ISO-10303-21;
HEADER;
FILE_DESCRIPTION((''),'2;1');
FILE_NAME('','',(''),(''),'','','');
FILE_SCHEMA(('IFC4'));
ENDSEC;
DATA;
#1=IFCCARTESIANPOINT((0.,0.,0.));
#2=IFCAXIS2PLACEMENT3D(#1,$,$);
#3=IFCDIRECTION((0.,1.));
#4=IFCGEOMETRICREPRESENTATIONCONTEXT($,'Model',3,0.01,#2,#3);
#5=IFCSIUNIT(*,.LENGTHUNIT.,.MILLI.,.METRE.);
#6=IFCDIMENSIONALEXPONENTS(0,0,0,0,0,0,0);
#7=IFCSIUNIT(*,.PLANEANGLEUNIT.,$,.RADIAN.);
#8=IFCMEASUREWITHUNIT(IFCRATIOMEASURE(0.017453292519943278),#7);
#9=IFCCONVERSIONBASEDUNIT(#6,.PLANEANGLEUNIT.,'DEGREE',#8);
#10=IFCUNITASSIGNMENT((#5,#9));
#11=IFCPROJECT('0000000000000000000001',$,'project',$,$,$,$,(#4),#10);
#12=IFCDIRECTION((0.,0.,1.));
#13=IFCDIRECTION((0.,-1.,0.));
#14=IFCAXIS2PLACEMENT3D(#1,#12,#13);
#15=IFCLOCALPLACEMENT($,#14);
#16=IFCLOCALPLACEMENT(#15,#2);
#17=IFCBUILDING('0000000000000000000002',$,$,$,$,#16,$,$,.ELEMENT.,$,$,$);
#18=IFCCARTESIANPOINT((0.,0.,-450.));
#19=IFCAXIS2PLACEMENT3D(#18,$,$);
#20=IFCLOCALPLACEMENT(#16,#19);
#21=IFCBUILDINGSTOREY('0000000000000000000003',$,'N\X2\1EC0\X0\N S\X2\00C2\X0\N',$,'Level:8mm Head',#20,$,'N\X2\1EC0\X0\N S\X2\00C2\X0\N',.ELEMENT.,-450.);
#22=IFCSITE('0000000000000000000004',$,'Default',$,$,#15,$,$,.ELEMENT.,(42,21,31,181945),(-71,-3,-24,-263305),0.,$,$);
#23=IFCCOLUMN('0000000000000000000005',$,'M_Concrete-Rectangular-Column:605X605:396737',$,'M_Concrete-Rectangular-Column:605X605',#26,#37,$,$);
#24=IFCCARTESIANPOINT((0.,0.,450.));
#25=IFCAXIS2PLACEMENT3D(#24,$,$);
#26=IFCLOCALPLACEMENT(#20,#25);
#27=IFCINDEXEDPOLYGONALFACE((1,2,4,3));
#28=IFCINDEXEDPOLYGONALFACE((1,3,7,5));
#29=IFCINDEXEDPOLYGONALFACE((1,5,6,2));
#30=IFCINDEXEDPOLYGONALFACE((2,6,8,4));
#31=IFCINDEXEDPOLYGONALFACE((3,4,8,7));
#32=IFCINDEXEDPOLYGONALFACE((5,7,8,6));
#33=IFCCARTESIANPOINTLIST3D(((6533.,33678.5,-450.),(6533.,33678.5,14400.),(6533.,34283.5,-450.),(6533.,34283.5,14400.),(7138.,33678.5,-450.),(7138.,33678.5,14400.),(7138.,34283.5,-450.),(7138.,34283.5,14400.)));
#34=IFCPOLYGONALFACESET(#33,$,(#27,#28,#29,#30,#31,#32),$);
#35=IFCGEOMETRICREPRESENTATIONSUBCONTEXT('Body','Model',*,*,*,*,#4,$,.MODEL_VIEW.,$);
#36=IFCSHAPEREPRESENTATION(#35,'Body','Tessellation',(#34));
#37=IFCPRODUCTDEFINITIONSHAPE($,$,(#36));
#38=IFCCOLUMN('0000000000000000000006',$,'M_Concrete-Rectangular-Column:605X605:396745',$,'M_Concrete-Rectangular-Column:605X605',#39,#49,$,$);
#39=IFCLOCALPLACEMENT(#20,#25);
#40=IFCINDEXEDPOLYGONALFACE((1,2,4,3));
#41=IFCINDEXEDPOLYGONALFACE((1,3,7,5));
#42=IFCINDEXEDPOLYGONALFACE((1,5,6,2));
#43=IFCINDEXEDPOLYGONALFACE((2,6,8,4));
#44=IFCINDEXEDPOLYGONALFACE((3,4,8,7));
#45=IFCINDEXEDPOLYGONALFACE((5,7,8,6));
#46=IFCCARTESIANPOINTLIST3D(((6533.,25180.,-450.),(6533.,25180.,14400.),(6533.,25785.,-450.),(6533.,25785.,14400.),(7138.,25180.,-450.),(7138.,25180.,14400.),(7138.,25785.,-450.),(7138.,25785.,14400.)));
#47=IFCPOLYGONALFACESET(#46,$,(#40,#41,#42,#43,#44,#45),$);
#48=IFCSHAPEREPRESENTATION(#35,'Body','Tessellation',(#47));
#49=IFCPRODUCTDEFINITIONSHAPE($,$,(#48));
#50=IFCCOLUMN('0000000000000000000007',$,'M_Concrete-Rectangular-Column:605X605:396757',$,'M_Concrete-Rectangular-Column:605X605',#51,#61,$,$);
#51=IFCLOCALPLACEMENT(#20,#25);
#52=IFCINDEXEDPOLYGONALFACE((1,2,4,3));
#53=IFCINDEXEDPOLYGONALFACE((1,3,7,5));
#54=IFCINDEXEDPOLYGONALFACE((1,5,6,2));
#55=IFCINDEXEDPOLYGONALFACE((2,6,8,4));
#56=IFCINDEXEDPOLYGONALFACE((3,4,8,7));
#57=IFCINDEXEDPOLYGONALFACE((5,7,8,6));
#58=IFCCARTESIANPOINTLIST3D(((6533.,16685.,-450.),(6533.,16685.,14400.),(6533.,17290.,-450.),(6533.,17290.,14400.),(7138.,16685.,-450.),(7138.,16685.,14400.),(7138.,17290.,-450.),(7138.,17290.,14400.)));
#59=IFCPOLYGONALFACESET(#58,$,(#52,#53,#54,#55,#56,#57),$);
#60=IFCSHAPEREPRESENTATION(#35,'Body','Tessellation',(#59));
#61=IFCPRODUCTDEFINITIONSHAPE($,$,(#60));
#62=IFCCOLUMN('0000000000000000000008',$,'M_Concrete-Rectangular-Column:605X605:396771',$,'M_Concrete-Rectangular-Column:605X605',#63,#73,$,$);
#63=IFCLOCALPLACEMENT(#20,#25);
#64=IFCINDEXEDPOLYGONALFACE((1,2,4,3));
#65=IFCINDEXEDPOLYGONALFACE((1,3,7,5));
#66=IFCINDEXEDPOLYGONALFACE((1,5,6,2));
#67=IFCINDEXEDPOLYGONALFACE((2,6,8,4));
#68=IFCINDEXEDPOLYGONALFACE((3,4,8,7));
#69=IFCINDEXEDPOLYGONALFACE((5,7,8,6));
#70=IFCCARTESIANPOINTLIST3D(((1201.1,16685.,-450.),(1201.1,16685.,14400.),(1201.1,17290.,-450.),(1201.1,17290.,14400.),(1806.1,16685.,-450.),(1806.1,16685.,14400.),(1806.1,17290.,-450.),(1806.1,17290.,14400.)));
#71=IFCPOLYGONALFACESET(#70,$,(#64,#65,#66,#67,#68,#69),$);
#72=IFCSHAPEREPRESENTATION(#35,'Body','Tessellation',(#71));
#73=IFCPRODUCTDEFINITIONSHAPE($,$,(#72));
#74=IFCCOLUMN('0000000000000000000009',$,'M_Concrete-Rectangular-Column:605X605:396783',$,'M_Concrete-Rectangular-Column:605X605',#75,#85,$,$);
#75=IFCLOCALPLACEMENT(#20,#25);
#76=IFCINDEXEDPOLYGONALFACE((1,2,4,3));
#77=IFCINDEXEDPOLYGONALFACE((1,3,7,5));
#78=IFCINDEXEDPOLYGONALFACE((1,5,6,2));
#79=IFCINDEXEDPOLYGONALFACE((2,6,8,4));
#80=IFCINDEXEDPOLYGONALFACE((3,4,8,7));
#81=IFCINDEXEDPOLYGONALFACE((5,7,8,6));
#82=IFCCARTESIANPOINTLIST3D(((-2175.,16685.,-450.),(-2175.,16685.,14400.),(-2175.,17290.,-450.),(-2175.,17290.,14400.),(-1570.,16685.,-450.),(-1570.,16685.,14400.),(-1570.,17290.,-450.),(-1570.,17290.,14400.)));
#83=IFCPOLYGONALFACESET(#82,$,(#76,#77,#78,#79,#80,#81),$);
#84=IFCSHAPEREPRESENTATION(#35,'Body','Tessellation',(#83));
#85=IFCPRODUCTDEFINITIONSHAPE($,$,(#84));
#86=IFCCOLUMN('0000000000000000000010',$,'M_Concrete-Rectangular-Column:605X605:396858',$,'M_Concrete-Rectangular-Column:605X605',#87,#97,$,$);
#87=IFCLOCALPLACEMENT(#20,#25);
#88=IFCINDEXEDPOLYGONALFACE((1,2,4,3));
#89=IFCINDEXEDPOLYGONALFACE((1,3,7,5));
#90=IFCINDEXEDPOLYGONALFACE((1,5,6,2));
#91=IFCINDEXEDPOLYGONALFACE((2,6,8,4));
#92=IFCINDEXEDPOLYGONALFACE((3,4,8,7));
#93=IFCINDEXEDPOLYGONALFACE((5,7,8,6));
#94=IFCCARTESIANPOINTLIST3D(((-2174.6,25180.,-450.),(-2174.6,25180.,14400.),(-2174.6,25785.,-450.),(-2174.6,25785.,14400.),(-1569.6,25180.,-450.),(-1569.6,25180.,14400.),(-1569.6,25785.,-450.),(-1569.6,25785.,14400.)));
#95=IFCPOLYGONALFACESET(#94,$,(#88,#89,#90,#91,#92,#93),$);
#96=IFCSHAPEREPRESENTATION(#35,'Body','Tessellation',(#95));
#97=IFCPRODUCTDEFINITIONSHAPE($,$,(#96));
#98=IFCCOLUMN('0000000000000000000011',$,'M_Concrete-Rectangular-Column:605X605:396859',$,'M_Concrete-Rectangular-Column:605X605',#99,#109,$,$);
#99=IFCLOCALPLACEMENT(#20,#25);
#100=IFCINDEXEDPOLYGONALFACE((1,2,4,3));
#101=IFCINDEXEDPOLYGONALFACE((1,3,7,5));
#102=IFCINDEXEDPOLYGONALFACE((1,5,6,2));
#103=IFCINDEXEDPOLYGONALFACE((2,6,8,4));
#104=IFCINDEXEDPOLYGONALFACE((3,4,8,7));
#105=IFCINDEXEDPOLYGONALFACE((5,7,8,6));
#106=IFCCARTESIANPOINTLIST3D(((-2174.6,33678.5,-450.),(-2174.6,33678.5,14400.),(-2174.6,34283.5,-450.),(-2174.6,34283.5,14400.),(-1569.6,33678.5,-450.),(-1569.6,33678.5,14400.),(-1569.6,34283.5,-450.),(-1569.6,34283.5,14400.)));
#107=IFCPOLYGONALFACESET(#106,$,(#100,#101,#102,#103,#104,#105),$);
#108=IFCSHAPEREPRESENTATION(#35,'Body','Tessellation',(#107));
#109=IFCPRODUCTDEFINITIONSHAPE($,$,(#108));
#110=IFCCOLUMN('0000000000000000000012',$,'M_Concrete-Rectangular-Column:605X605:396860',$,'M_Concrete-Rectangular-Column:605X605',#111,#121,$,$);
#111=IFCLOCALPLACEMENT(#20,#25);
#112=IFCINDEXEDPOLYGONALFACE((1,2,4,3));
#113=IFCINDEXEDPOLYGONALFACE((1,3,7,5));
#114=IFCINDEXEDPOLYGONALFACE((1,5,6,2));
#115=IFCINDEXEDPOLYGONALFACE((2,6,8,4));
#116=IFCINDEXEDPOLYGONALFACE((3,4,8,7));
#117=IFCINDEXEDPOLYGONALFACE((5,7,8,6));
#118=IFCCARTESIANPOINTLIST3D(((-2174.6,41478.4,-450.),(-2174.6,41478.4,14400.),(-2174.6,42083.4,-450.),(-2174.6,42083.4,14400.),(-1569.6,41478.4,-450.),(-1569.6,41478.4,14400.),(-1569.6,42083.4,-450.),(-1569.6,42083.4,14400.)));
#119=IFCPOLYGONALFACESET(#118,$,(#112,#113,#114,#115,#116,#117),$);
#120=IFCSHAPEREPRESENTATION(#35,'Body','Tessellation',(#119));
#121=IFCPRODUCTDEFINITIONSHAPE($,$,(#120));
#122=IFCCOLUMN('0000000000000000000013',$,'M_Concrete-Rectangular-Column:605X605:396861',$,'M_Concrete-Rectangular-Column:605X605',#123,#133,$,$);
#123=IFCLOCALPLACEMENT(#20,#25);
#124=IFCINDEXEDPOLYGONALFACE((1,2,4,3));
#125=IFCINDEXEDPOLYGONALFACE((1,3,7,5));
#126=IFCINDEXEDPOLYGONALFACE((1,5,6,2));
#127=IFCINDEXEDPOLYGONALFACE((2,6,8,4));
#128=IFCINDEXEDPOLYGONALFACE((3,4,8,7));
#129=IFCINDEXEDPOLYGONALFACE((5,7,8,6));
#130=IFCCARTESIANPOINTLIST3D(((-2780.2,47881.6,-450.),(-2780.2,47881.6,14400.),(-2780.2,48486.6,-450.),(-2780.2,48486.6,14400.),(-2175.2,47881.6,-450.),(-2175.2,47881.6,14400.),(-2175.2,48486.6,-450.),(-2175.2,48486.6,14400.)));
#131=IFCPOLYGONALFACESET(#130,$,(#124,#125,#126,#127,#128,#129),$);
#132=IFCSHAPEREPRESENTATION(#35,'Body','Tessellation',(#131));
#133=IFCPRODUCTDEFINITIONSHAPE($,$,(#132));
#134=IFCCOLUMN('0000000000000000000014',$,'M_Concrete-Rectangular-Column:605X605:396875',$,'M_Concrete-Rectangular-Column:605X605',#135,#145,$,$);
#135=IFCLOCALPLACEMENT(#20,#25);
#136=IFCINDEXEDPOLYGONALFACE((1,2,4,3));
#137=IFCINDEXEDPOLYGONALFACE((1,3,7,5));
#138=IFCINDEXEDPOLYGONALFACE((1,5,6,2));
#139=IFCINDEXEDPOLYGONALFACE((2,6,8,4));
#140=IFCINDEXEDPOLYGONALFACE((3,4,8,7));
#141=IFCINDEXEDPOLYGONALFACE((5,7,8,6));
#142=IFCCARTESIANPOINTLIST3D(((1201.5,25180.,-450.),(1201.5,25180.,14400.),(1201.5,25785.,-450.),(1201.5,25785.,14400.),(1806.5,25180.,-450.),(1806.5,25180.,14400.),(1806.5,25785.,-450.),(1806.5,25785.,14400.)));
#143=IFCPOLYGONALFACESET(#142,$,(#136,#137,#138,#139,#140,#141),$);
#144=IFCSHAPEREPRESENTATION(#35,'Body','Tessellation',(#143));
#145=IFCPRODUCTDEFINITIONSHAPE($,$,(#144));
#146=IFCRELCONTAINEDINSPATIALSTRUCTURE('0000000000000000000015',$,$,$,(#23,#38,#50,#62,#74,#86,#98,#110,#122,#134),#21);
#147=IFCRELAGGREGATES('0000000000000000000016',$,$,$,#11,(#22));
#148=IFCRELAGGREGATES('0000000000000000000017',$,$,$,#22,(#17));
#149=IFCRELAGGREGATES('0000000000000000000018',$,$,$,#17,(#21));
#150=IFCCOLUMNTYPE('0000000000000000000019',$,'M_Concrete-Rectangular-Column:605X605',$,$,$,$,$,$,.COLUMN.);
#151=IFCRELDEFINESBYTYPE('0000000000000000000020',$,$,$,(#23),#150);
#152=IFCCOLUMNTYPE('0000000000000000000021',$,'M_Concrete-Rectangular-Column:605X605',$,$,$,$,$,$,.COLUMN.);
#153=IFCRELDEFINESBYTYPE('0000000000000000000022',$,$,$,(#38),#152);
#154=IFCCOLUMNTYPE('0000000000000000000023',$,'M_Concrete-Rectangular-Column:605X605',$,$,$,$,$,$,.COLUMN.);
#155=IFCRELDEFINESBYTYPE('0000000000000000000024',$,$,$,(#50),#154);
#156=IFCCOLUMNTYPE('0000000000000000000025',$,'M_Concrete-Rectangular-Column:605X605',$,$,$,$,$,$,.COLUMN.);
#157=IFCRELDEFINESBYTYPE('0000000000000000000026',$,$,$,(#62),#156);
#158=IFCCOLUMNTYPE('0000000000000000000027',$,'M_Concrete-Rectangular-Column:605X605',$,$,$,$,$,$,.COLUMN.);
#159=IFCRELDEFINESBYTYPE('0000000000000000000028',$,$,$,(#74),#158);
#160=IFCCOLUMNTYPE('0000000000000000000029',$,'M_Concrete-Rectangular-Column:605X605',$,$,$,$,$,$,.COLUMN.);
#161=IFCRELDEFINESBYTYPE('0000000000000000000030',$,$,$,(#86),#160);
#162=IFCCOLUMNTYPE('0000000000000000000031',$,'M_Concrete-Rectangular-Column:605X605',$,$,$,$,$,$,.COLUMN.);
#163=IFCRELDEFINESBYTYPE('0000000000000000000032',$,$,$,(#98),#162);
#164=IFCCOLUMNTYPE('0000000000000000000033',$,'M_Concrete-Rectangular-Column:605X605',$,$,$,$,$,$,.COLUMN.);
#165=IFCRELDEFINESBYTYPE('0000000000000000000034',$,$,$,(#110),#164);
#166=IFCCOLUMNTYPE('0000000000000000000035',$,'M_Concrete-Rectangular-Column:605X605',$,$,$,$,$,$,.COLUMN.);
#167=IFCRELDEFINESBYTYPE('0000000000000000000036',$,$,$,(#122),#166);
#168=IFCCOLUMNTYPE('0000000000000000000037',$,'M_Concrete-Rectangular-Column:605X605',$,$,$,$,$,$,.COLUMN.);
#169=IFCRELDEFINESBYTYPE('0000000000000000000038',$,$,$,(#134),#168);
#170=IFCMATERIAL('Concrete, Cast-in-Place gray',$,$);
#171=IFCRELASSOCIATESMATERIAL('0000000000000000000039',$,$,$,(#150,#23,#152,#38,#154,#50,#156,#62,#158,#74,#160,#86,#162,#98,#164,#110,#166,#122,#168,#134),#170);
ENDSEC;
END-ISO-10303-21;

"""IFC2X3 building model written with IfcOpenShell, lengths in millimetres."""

from ifc_helpers import new_model, entity, si_unit, converted_unit, direction, frame, frame_2d, origin, origin_2d_with_axis, place, context, subcontext, project, spatial, rectangle, extrude, source, transform, mapped, material, type_object, type_shapes, element, save


model = new_model("IFC2X3")

# Units and contexts
model_context = context("Model", 3, precision=0.01, world=origin(), true_north=direction((0.0, 1.0)))
body_context = subcontext(model_context, "Body", "Model", "MODEL_VIEW")
ifc_project = project(units=[si_unit("LENGTHUNIT", "METRE", prefix="MILLI"), converted_unit("PLANEANGLEUNIT", "DEGREE", entity("IfcRatioMeasure", 0.017453292519943278), si_unit("PLANEANGLEUNIT", "RADIAN"), dimensions=[0, 0, 0, 0, 0, 0, 0])], contexts=[model_context])

# Site, building, storey
site_placement = place(None, frame((0.0, 0.0, 0.0), z_axis=(0.0, 0.0, 1.0), x_axis=(0.0, -1.0, 0.0)))
site = spatial("IfcSite", under=ifc_project, at=site_placement, Name="Default", CompositionType="ELEMENT", RefLatitude=(42, 21, 31, 181945), RefLongitude=(-71, -3, -24, -263305), RefElevation=0.0)
building_placement = place(site_placement, origin())
building = spatial("IfcBuilding", under=site, at=building_placement, CompositionType="ELEMENT")
storey_placement = place(building_placement, frame((0.0, 0.0, -450.0)))
storey = spatial("IfcBuildingStorey", under=building, at=storey_placement, Name="NỀN SÂN", ObjectType="Level:8mm Head", LongName="NỀN SÂN", CompositionType="ELEMENT", Elevation=-450.0)

# Columns
ifc_material_1 = material(Name="Concrete, Cast-in-Place gray")
column_type_1 = type_object("IfcColumnType", Name="M_Concrete-Rectangular-Column:605X605", PredefinedType="COLUMN", material=ifc_material_1)
shared_shape_1 = source(origin(), body_context, "Body", "SweptSolid", [
    extrude(rectangle(XDim=605.0, YDim=605.0, at=frame_2d((0.0, 0.0), x_axis=(1.0, 0.0))), frame((6835.5, 33981.0, -450.0), z_axis=(0.0, 0.0, 1.0), x_axis=(0.0, -1.0, 0.0)), (0.0, 0.0, 1.0), 14850.0),
])
type_shapes(column_type_1, [shared_shape_1])
column_1_placement = place(storey_placement, frame((0.0, 0.0, 450.0)))
element("IfcColumn", 1, at=column_1_placement, inside=storey, type_object=column_type_1, material=ifc_material_1, Name="M_Concrete-Rectangular-Column:605X605:396737", ObjectType="M_Concrete-Rectangular-Column:605X605", context=body_context, shape_type="MappedRepresentation", body=[
    mapped(shared_shape_1, transform((0.0, 0.0, 0.0), scale=1.0)),
])
column_type_2 = type_object("IfcColumnType", Name="M_Concrete-Rectangular-Column:605X605", PredefinedType="COLUMN", material=ifc_material_1)
shared_shape_2 = source(origin(), body_context, "Body", "SweptSolid", [
    extrude(rectangle(XDim=605.0, YDim=605.0, at=frame_2d((0.0, 0.0), x_axis=(1.0, 0.0))), frame((6835.5, 25482.5, -450.0), z_axis=(0.0, 0.0, 1.0), x_axis=(0.0, -1.0, 0.0)), (0.0, 0.0, 1.0), 14850.0),
])
type_shapes(column_type_2, [shared_shape_2])
column_2_placement = place(storey_placement, frame((0.0, 0.0, 450.0)))
element("IfcColumn", 2, at=column_2_placement, inside=storey, type_object=column_type_2, material=ifc_material_1, Name="M_Concrete-Rectangular-Column:605X605:396745", ObjectType="M_Concrete-Rectangular-Column:605X605", context=body_context, shape_type="MappedRepresentation", body=[
    mapped(shared_shape_2, transform((0.0, 0.0, 0.0), scale=1.0)),
])
column_type_3 = type_object("IfcColumnType", Name="M_Concrete-Rectangular-Column:605X605", PredefinedType="COLUMN", material=ifc_material_1)
shared_shape_3 = source(origin(), body_context, "Body", "SweptSolid", [
    extrude(rectangle(XDim=605.0, YDim=605.0, at=frame_2d((0.0, 0.0), x_axis=(1.0, 0.0))), frame((6835.5, 16987.5, -450.0), z_axis=(0.0, 0.0, 1.0), x_axis=(0.0, -1.0, 0.0)), (0.0, 0.0, 1.0), 14850.0),
])
type_shapes(column_type_3, [shared_shape_3])
column_3_placement = place(storey_placement, frame((0.0, 0.0, 450.0)))
element("IfcColumn", 3, at=column_3_placement, inside=storey, type_object=column_type_3, material=ifc_material_1, Name="M_Concrete-Rectangular-Column:605X605:396757", ObjectType="M_Concrete-Rectangular-Column:605X605", context=body_context, shape_type="MappedRepresentation", body=[
    mapped(shared_shape_3, transform((0.0, 0.0, 0.0), scale=1.0)),
])
column_type_4 = type_object("IfcColumnType", Name="M_Concrete-Rectangular-Column:605X605", PredefinedType="COLUMN", material=ifc_material_1)
shared_shape_4 = source(origin(), body_context, "Body", "SweptSolid", [
    extrude(rectangle(XDim=605.0, YDim=605.0, at=origin_2d_with_axis()), frame((1503.6, 16987.5, -450.0), z_axis=(0.0, 0.0, 1.0), x_axis=(0.0, -1.0, 0.0)), (0.0, 0.0, 1.0), 14850.0),
])
type_shapes(column_type_4, [shared_shape_4])
column_4_placement = place(storey_placement, frame((0.0, 0.0, 450.0)))
element("IfcColumn", 4, at=column_4_placement, inside=storey, type_object=column_type_4, material=ifc_material_1, Name="M_Concrete-Rectangular-Column:605X605:396771", ObjectType="M_Concrete-Rectangular-Column:605X605", context=body_context, shape_type="MappedRepresentation", body=[
    mapped(shared_shape_4, transform((0.0, 0.0, 0.0), scale=1.0)),
])
column_type_5 = type_object("IfcColumnType", Name="M_Concrete-Rectangular-Column:605X605", PredefinedType="COLUMN", material=ifc_material_1)
shared_shape_5 = source(origin(), body_context, "Body", "SweptSolid", [
    extrude(rectangle(XDim=605.0, YDim=605.0, at=origin_2d_with_axis()), frame((-1872.5, 16987.5, -450.0), z_axis=(0.0, 0.0, 1.0), x_axis=(0.0, -1.0, 0.0)), (0.0, 0.0, 1.0), 14850.0),
])
type_shapes(column_type_5, [shared_shape_5])
column_5_placement = place(storey_placement, frame((0.0, 0.0, 450.0)))
element("IfcColumn", 5, at=column_5_placement, inside=storey, type_object=column_type_5, material=ifc_material_1, Name="M_Concrete-Rectangular-Column:605X605:396783", ObjectType="M_Concrete-Rectangular-Column:605X605", context=body_context, shape_type="MappedRepresentation", body=[
    mapped(shared_shape_5, transform((0.0, 0.0, 0.0), scale=1.0)),
])
column_type_6 = type_object("IfcColumnType", Name="M_Concrete-Rectangular-Column:605X605", PredefinedType="COLUMN", material=ifc_material_1)
shared_shape_6 = source(origin(), body_context, "Body", "SweptSolid", [
    extrude(rectangle(XDim=605.0, YDim=605.0, at=origin_2d_with_axis()), frame((-1872.1, 25482.5, -450.0), z_axis=(0.0, 0.0, 1.0), x_axis=(0.0, -1.0, 0.0)), (0.0, 0.0, 1.0), 14850.0),
])
type_shapes(column_type_6, [shared_shape_6])
column_6_placement = place(storey_placement, frame((0.0, 0.0, 450.0)))
element("IfcColumn", 6, at=column_6_placement, inside=storey, type_object=column_type_6, material=ifc_material_1, Name="M_Concrete-Rectangular-Column:605X605:396858", ObjectType="M_Concrete-Rectangular-Column:605X605", context=body_context, shape_type="MappedRepresentation", body=[
    mapped(shared_shape_6, transform((0.0, 0.0, 0.0), scale=1.0)),
])
column_type_7 = type_object("IfcColumnType", Name="M_Concrete-Rectangular-Column:605X605", PredefinedType="COLUMN", material=ifc_material_1)
shared_shape_7 = source(origin(), body_context, "Body", "SweptSolid", [
    extrude(rectangle(XDim=605.0, YDim=605.0, at=origin_2d_with_axis()), frame((-1872.1, 33981.0, -450.0), z_axis=(0.0, 0.0, 1.0), x_axis=(0.0, -1.0, 0.0)), (0.0, 0.0, 1.0), 14850.0),
])
type_shapes(column_type_7, [shared_shape_7])
column_7_placement = place(storey_placement, frame((0.0, 0.0, 450.0)))
element("IfcColumn", 7, at=column_7_placement, inside=storey, type_object=column_type_7, material=ifc_material_1, Name="M_Concrete-Rectangular-Column:605X605:396859", ObjectType="M_Concrete-Rectangular-Column:605X605", context=body_context, shape_type="MappedRepresentation", body=[
    mapped(shared_shape_7, transform((0.0, 0.0, 0.0), scale=1.0)),
])
column_type_8 = type_object("IfcColumnType", Name="M_Concrete-Rectangular-Column:605X605", PredefinedType="COLUMN", material=ifc_material_1)
shared_shape_8 = source(origin(), body_context, "Body", "SweptSolid", [
    extrude(rectangle(XDim=605.0, YDim=605.0, at=origin_2d_with_axis()), frame((-1872.1, 41780.9, -450.0), z_axis=(0.0, 0.0, 1.0), x_axis=(0.0, -1.0, 0.0)), (0.0, 0.0, 1.0), 14850.0),
])
type_shapes(column_type_8, [shared_shape_8])
column_8_placement = place(storey_placement, frame((0.0, 0.0, 450.0)))
element("IfcColumn", 8, at=column_8_placement, inside=storey, type_object=column_type_8, material=ifc_material_1, Name="M_Concrete-Rectangular-Column:605X605:396860", ObjectType="M_Concrete-Rectangular-Column:605X605", context=body_context, shape_type="MappedRepresentation", body=[
    mapped(shared_shape_8, transform((0.0, 0.0, 0.0), scale=1.0)),
])
column_type_9 = type_object("IfcColumnType", Name="M_Concrete-Rectangular-Column:605X605", PredefinedType="COLUMN", material=ifc_material_1)
shared_shape_9 = source(origin(), body_context, "Body", "SweptSolid", [
    extrude(rectangle(XDim=605.0, YDim=605.0, at=origin_2d_with_axis()), frame((-2477.7, 48184.1, -450.0), z_axis=(0.0, 0.0, 1.0), x_axis=(0.0, -1.0, 0.0)), (0.0, 0.0, 1.0), 14850.0),
])
type_shapes(column_type_9, [shared_shape_9])
column_9_placement = place(storey_placement, frame((0.0, 0.0, 450.0)))
element("IfcColumn", 9, at=column_9_placement, inside=storey, type_object=column_type_9, material=ifc_material_1, Name="M_Concrete-Rectangular-Column:605X605:396861", ObjectType="M_Concrete-Rectangular-Column:605X605", context=body_context, shape_type="MappedRepresentation", body=[
    mapped(shared_shape_9, transform((0.0, 0.0, 0.0), scale=1.0)),
])
column_type_10 = type_object("IfcColumnType", Name="M_Concrete-Rectangular-Column:605X605", PredefinedType="COLUMN", material=ifc_material_1)
shared_shape_10 = source(origin(), body_context, "Body", "SweptSolid", [
    extrude(rectangle(XDim=605.0, YDim=605.0, at=origin_2d_with_axis()), frame((1504.0, 25482.5, -450.0), z_axis=(0.0, 0.0, 1.0), x_axis=(0.0, -1.0, 0.0)), (0.0, 0.0, 1.0), 14850.0),
])
type_shapes(column_type_10, [shared_shape_10])
column_10_placement = place(storey_placement, frame((0.0, 0.0, 450.0)))
element("IfcColumn", 10, at=column_10_placement, inside=storey, type_object=column_type_10, material=ifc_material_1, Name="M_Concrete-Rectangular-Column:605X605:396875", ObjectType="M_Concrete-Rectangular-Column:605X605", context=body_context, shape_type="MappedRepresentation", body=[
    mapped(shared_shape_10, transform((0.0, 0.0, 0.0), scale=1.0)),
])

save(model, "model.ifc")
